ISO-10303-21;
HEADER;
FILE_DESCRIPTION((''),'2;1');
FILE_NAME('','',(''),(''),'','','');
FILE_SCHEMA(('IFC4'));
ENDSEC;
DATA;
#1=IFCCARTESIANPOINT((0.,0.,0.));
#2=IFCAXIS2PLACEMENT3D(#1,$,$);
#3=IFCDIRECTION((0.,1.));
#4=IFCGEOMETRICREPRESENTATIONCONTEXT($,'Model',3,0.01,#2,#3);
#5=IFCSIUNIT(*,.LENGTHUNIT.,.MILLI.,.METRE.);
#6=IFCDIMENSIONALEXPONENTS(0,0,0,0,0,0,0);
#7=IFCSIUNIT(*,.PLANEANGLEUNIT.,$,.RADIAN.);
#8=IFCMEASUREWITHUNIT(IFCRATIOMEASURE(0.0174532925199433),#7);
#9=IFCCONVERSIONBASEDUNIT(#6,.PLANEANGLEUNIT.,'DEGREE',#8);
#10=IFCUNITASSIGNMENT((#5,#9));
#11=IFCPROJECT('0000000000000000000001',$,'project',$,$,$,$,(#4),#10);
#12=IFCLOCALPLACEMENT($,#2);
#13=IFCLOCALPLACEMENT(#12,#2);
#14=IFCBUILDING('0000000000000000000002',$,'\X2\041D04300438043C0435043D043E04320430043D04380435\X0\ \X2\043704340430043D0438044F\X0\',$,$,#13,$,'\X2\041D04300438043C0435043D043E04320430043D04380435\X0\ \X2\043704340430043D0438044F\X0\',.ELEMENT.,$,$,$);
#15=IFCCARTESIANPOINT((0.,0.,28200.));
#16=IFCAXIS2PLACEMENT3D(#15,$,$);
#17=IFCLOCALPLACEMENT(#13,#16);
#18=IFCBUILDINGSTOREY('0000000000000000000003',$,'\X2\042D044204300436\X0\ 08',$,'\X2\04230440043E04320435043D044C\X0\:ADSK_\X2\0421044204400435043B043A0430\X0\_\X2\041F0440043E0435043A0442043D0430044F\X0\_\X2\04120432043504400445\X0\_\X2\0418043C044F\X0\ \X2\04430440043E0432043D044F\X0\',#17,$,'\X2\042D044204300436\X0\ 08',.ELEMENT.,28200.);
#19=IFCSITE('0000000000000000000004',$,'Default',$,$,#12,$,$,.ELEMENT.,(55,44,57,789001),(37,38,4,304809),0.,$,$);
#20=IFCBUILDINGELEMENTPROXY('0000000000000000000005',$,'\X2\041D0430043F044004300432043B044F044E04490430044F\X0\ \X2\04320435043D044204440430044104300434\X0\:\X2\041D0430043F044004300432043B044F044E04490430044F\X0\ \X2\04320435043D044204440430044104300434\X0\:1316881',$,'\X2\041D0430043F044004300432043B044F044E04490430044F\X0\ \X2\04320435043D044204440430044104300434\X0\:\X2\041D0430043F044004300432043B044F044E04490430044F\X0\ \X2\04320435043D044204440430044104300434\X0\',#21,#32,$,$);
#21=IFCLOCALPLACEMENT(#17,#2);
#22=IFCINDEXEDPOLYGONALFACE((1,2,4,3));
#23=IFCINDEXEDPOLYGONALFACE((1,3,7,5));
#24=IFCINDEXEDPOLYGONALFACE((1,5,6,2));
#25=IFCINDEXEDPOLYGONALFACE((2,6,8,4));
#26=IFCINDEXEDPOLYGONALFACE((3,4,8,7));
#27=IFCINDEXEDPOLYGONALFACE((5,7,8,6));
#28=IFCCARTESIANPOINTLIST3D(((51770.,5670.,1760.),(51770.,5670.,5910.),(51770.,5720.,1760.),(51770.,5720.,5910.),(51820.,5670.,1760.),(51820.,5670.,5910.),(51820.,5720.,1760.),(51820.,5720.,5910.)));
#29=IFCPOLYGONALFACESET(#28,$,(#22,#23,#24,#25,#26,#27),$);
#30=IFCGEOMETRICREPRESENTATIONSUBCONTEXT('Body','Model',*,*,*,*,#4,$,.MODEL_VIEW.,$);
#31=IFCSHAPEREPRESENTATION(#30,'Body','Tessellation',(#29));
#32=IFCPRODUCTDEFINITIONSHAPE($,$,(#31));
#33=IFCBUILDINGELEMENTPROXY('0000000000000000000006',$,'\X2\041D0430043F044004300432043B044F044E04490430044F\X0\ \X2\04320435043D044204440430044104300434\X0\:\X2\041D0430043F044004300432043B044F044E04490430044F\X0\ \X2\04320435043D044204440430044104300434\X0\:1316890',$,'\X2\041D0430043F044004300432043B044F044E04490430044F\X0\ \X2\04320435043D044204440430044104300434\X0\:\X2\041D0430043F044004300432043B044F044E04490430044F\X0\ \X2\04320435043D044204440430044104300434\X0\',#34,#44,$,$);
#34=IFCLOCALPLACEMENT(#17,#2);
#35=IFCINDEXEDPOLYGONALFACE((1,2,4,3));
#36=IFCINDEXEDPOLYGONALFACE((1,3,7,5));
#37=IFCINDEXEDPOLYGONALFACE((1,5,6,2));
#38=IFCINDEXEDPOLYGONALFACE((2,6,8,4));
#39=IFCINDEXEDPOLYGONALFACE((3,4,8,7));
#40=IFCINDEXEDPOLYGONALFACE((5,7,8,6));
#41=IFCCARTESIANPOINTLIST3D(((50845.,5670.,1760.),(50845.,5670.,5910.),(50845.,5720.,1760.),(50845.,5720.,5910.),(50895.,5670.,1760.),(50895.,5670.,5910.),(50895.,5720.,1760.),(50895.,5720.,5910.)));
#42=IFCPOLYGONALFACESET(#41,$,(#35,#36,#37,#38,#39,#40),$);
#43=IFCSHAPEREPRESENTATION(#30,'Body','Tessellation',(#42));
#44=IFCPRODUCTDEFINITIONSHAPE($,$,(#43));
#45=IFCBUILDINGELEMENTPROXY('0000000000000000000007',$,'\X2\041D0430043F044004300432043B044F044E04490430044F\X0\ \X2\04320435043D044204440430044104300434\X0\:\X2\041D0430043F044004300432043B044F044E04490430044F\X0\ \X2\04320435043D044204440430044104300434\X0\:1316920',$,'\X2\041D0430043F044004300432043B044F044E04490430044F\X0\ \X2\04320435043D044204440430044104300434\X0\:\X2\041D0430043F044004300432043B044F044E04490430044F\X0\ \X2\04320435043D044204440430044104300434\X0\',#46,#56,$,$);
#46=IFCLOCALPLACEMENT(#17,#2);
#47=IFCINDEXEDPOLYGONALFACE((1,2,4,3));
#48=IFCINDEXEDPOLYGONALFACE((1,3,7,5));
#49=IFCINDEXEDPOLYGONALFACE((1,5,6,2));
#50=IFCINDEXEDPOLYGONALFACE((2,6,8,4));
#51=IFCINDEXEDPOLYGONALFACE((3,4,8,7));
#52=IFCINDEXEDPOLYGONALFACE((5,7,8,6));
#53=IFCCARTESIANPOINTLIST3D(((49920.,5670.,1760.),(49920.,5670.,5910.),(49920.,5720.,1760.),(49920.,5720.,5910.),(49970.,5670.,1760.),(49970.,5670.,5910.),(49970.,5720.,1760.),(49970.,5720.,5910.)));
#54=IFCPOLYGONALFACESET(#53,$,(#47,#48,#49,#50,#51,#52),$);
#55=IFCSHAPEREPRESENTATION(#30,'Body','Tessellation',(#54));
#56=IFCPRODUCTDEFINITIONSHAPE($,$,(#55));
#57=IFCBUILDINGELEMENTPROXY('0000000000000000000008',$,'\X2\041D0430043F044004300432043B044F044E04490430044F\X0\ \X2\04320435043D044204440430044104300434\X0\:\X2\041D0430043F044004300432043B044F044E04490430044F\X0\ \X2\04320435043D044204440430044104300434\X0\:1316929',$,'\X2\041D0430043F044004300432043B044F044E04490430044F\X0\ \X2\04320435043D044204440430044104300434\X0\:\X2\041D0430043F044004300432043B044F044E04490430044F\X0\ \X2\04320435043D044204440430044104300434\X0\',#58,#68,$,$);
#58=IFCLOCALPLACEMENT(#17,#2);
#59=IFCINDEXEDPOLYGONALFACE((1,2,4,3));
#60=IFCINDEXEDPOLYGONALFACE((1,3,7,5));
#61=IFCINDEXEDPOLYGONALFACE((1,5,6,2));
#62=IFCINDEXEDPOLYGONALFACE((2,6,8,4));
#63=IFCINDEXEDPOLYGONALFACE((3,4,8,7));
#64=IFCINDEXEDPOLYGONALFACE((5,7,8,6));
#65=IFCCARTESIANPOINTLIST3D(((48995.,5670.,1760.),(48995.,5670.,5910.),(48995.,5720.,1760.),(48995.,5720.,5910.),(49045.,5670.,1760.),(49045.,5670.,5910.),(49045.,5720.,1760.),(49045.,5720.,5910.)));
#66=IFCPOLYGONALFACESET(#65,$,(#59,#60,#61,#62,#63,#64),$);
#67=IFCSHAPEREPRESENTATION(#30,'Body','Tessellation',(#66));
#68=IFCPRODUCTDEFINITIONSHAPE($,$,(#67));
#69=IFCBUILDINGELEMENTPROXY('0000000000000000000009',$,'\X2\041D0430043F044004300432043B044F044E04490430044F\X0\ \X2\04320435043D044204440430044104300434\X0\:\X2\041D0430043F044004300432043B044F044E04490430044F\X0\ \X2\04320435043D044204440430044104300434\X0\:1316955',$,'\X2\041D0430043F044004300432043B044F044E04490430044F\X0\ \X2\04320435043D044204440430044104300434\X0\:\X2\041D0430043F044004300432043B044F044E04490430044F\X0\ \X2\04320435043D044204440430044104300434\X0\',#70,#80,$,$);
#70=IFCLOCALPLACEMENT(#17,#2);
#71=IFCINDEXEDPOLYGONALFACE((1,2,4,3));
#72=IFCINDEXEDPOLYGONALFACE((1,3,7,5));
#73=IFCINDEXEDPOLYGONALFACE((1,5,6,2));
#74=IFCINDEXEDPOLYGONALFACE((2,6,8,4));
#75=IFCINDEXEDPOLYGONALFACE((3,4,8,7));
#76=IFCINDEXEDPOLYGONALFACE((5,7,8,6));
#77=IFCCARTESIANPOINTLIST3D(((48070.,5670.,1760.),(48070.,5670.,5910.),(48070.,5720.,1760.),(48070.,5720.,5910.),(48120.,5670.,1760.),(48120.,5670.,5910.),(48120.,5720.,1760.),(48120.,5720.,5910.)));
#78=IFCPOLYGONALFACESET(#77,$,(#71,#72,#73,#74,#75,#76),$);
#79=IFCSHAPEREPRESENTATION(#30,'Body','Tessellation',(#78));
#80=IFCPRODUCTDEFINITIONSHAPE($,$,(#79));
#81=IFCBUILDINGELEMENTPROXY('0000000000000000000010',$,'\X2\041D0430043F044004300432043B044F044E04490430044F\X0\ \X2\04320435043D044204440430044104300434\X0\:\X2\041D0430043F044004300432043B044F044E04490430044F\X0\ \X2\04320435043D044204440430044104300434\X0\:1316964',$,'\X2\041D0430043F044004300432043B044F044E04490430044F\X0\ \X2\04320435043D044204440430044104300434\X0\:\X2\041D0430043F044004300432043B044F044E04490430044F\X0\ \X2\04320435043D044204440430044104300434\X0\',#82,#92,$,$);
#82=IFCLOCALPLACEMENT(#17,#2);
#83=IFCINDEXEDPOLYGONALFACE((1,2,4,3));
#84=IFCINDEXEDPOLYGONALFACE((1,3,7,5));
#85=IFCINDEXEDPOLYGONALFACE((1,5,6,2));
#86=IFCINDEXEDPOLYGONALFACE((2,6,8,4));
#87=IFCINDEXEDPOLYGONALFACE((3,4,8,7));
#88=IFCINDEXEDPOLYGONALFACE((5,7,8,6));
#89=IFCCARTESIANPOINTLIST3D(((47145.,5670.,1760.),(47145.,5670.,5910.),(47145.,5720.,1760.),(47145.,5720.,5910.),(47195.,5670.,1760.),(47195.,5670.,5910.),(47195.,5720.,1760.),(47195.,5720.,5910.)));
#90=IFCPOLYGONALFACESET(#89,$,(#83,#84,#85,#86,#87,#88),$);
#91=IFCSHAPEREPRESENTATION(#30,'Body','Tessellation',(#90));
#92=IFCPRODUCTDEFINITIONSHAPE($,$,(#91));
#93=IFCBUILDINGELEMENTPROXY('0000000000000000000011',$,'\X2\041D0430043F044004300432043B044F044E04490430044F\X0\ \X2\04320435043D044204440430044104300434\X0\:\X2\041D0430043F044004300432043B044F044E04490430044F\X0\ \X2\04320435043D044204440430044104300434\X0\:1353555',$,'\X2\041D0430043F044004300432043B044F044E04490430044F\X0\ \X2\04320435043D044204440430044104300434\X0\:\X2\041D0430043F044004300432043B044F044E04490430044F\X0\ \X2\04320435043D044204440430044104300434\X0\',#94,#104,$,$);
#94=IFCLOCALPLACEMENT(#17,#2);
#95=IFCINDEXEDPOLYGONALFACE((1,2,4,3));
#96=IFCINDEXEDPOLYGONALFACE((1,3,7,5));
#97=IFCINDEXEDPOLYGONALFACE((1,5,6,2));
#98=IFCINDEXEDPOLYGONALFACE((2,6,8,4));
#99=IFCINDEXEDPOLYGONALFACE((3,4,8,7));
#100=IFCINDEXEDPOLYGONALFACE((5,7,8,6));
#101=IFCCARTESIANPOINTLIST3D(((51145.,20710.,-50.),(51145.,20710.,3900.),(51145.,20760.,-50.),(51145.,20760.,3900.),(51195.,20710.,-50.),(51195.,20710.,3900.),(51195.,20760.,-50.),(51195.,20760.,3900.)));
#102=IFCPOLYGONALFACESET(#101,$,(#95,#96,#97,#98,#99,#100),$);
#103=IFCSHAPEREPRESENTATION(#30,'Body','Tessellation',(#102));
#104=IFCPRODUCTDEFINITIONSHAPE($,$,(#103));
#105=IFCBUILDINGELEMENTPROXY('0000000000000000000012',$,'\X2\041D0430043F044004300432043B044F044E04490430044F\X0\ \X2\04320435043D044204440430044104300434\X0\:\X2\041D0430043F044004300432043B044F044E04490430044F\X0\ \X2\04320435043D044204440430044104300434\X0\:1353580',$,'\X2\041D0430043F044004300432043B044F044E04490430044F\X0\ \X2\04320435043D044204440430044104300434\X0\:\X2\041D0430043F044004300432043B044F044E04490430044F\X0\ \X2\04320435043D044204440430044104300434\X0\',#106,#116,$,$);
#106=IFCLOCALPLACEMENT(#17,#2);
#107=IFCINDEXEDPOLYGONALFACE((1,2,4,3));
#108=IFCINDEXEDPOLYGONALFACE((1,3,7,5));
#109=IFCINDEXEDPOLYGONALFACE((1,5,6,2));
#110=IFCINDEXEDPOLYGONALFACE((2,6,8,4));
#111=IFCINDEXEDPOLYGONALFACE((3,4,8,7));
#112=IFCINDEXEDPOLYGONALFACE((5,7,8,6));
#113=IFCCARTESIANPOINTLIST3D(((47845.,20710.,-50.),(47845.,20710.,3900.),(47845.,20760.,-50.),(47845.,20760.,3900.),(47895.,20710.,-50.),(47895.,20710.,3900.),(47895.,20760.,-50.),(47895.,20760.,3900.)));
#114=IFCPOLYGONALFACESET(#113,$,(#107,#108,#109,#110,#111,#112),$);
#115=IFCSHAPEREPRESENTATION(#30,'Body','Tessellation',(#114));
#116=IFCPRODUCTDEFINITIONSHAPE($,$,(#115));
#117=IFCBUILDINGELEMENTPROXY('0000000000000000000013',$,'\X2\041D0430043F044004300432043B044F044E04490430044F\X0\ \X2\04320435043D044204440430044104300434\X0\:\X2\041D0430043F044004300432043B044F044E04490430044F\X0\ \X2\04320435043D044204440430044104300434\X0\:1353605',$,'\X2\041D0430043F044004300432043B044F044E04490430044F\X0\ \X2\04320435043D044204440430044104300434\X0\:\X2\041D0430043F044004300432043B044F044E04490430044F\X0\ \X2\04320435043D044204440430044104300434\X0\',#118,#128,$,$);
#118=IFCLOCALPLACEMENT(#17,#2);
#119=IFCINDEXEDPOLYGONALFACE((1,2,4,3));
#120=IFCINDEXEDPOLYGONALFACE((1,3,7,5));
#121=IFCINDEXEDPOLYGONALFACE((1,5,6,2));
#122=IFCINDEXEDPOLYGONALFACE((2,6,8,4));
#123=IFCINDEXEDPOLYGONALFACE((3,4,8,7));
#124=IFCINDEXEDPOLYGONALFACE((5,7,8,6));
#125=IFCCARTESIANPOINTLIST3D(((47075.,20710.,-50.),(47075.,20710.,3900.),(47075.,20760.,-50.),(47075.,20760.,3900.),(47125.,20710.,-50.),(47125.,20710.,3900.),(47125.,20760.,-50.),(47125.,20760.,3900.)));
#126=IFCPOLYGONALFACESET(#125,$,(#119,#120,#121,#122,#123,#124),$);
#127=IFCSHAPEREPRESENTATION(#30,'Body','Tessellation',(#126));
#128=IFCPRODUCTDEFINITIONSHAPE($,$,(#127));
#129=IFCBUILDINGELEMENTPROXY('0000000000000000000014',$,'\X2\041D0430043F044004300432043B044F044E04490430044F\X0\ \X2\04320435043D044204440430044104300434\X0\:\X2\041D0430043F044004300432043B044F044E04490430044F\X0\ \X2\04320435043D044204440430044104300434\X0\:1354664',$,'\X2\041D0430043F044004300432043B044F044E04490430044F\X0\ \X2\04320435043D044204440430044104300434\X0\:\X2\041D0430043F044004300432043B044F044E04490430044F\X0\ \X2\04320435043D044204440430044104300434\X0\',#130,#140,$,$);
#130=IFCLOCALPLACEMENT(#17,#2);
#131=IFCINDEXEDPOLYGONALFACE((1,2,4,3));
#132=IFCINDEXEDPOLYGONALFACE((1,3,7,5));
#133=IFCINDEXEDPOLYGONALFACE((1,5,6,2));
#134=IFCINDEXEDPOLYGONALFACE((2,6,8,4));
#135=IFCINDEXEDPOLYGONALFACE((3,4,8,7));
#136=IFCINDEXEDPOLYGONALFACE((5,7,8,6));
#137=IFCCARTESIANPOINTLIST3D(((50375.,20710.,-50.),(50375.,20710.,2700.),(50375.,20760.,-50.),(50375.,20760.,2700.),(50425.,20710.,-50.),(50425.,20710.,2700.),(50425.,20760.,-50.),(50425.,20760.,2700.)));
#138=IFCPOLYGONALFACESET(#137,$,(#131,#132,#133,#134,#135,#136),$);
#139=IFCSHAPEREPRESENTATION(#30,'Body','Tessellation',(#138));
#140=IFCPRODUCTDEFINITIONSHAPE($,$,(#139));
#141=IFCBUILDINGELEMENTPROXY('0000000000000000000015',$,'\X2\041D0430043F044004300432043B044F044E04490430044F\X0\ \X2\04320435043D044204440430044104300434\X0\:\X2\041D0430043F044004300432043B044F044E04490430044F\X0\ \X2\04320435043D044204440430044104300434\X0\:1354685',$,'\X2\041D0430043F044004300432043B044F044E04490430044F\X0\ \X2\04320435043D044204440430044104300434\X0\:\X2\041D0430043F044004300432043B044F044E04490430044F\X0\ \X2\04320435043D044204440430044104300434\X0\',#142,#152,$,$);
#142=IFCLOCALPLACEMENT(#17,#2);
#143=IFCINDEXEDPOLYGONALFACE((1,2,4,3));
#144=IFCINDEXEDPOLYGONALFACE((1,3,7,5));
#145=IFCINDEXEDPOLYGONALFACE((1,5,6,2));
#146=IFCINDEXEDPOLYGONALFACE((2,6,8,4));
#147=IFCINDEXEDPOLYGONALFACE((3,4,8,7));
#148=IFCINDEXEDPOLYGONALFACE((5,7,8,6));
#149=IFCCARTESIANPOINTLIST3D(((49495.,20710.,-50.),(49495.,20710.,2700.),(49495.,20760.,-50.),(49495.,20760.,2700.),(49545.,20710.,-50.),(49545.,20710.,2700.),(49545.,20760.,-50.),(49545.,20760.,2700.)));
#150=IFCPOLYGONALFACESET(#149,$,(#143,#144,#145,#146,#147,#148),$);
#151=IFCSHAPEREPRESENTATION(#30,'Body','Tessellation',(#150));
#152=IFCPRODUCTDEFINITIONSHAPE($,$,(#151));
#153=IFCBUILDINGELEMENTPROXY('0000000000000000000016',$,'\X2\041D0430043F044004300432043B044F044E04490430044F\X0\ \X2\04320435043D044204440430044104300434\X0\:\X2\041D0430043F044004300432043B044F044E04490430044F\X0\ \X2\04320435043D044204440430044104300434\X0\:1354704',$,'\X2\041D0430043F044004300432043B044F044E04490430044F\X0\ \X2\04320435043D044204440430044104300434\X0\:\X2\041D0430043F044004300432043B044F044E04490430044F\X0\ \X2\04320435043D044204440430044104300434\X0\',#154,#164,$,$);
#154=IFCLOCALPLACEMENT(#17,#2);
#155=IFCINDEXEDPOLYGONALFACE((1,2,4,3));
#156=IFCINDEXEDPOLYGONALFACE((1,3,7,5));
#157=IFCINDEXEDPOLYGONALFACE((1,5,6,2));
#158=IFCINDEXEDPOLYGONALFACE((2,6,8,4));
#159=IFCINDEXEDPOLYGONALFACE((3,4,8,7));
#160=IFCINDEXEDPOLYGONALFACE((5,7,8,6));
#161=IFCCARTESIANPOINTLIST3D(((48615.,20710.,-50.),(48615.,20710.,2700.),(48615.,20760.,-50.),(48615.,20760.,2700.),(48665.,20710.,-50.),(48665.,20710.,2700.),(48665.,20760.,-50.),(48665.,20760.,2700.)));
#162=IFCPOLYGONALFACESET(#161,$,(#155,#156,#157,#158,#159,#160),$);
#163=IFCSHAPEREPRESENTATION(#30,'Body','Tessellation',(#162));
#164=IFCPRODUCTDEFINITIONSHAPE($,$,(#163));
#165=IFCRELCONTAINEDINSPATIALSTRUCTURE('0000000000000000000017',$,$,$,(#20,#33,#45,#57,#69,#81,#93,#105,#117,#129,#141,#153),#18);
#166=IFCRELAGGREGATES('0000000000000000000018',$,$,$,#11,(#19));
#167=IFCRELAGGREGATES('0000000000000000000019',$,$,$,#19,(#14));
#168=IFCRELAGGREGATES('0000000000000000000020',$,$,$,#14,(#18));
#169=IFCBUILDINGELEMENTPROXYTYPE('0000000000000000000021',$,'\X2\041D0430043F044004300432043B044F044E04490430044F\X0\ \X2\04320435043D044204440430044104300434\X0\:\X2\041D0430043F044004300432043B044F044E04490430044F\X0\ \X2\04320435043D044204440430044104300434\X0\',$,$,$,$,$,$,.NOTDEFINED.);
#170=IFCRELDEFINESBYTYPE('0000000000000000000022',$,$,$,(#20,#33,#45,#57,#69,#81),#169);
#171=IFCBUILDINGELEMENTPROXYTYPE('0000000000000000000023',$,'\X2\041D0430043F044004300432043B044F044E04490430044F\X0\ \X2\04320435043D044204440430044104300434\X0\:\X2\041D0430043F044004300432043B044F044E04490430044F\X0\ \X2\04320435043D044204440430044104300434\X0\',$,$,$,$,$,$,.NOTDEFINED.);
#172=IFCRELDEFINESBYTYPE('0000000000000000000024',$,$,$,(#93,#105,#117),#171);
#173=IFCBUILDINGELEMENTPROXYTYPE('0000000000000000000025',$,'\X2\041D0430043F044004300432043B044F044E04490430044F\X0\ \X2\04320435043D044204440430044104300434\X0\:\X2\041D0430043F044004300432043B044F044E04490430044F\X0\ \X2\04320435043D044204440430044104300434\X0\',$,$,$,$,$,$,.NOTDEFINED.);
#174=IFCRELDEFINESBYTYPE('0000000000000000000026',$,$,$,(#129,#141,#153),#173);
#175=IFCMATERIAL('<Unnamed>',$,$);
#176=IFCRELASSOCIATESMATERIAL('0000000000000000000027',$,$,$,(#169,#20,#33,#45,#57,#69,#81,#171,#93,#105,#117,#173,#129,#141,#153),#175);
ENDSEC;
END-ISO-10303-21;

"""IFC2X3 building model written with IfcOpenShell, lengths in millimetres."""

from ifc_helpers import new_model, entity, si_unit, converted_unit, direction, frame, origin, origin_2d_with_axis, place, context, subcontext, project, spatial, rectangle, extrude, source, transform, mapped, material, type_object, type_shapes, element, save


model = new_model("IFC2X3")

# Units and contexts
model_context = context("Model", 3, precision=0.01, world=origin(), true_north=direction((0.0, 1.0)))
body_context = subcontext(model_context, "Body", "Model", "MODEL_VIEW")
ifc_project = project(units=[si_unit("LENGTHUNIT", "METRE", prefix="MILLI"), converted_unit("PLANEANGLEUNIT", "DEGREE", entity("IfcRatioMeasure", 0.0174532925199433), si_unit("PLANEANGLEUNIT", "RADIAN"), dimensions=[0, 0, 0, 0, 0, 0, 0])], contexts=[model_context])

# Site, building, storey
site_placement = place(None, origin())
site = spatial("IfcSite", under=ifc_project, at=site_placement, Name="Default", CompositionType="ELEMENT", RefLatitude=(55, 44, 57, 789001), RefLongitude=(37, 38, 4, 304809), RefElevation=0.0)
building_placement = place(site_placement, origin())
building = spatial("IfcBuilding", under=site, at=building_placement, Name="Наименование здания", LongName="Наименование здания", CompositionType="ELEMENT")
storey_placement = place(building_placement, frame((0.0, 0.0, 28200.0)))
storey = spatial("IfcBuildingStorey", under=building, at=storey_placement, Name="Этаж 08", ObjectType="Уровень:ADSK_Стрелка_Проектная_Вверх_Имя уровня", LongName="Этаж 08", CompositionType="ELEMENT", Elevation=28200.0)

# Building element proxies
ifc_material_1 = material(Name="<Unnamed>")
building_element_proxy_type_1 = type_object("IfcBuildingElementProxyType", Name="Направляющая вентфасад:Направляющая вентфасад", PredefinedType="NOTDEFINED", material=ifc_material_1)
shared_shape_1 = source(origin(), body_context, "Body", "SweptSolid", [
    extrude(rectangle(XDim=50.0, YDim=50.0, at=origin_2d_with_axis()), frame((25.0, -25.0, 0.0), z_axis=(0.0, 0.0, 1.0), x_axis=(-1.0, 0.0, 0.0)), (0.0, 0.0, 1.0), 4150.0),
])
type_shapes(building_element_proxy_type_1, [shared_shape_1])
for number, where, name in (
    (1, (51770.0, 5720.0, 1760.0), "Направляющая вентфасад:Направляющая вентфасад:1316881"),
    (2, (50845.0, 5720.0, 1760.0), "Направляющая вентфасад:Направляющая вентфасад:1316890"),
    (3, (49920.0, 5720.0, 1760.0), "Направляющая вентфасад:Направляющая вентфасад:1316920"),
    (4, (48995.0, 5720.0, 1760.0), "Направляющая вентфасад:Направляющая вентфасад:1316929"),
    (5, (48070.0, 5720.0, 1760.0), "Направляющая вентфасад:Направляющая вентфасад:1316955"),
    (6, (47145.0, 5720.0, 1760.0), "Направляющая вентфасад:Направляющая вентфасад:1316964"),
):
    element("IfcBuildingElementProxy", number, at=place(storey_placement, frame(where)), inside=storey, type_object=building_element_proxy_type_1, material=ifc_material_1, Name=name, ObjectType="Направляющая вентфасад:Направляющая вентфасад", context=body_context, shape_type="MappedRepresentation", body=[
        mapped(shared_shape_1, transform((0.0, 0.0, 0.0), scale=1.0)),
    ])
building_element_proxy_type_2 = type_object("IfcBuildingElementProxyType", Name="Направляющая вентфасад:Направляющая вентфасад", PredefinedType="NOTDEFINED", material=ifc_material_1)
shared_shape_2 = source(origin(), body_context, "Body", "SweptSolid", [
    extrude(rectangle(XDim=50.0, YDim=50.0, at=origin_2d_with_axis()), frame((25.0, -25.0, 0.0), z_axis=(0.0, 0.0, 1.0), x_axis=(-1.0, 0.0, 0.0)), (0.0, 0.0, 1.0), 3950.0),
])
type_shapes(building_element_proxy_type_2, [shared_shape_2])
for number, where, z_axis, x_axis, name in (
    (7, (51195.0, 20710.0, -50.0), (0.0, 0.0, 1.0), (-1.0, 0.0, 0.0), "Направляющая вентфасад:Направляющая вентфасад:1353555"),
    (8, (47895.0, 20710.0, -50.0), (0.0, 0.0, 1.0), (-1.0, 0.0, 0.0), "Направляющая вентфасад:Направляющая вентфасад:1353580"),
    (9, (47125.0, 20710.0, -50.0), (0.0, 0.0, 1.0), (-1.0, 0.0, 0.0), "Направляющая вентфасад:Направляющая вентфасад:1353605"),
):
    element("IfcBuildingElementProxy", number, at=place(storey_placement, frame(where, z_axis=z_axis, x_axis=x_axis)), inside=storey, type_object=building_element_proxy_type_2, material=ifc_material_1, Name=name, ObjectType="Направляющая вентфасад:Направляющая вентфасад", context=body_context, shape_type="MappedRepresentation", body=[
        mapped(shared_shape_2, transform((0.0, 0.0, 0.0), scale=1.0)),
    ])
building_element_proxy_type_3 = type_object("IfcBuildingElementProxyType", Name="Направляющая вентфасад:Направляющая вентфасад", PredefinedType="NOTDEFINED", material=ifc_material_1)
shared_shape_3 = source(origin(), body_context, "Body", "SweptSolid", [
    extrude(rectangle(XDim=50.0, YDim=50.0, at=origin_2d_with_axis()), frame((25.0, -25.0, 0.0), z_axis=(0.0, 0.0, 1.0), x_axis=(-1.0, 0.0, 0.0)), (0.0, 0.0, 1.0), 2750.0),
])
type_shapes(building_element_proxy_type_3, [shared_shape_3])
for number, where, z_axis, x_axis, name in (
    (10, (50425.0, 20710.0, -50.0), (0.0, 0.0, 1.0), (-1.0, 0.0, 0.0), "Направляющая вентфасад:Направляющая вентфасад:1354664"),
    (11, (49545.0, 20710.0, -50.0), (0.0, 0.0, 1.0), (-1.0, 0.0, 0.0), "Направляющая вентфасад:Направляющая вентфасад:1354685"),
    (12, (48665.0, 20710.0, -50.0), (0.0, 0.0, 1.0), (-1.0, 0.0, 0.0), "Направляющая вентфасад:Направляющая вентфасад:1354704"),
):
    element("IfcBuildingElementProxy", number, at=place(storey_placement, frame(where, z_axis=z_axis, x_axis=x_axis)), inside=storey, type_object=building_element_proxy_type_3, material=ifc_material_1, Name=name, ObjectType="Направляющая вентфасад:Направляющая вентфасад", context=body_context, shape_type="MappedRepresentation", body=[
        mapped(shared_shape_3, transform((0.0, 0.0, 0.0), scale=1.0)),
    ])

save(model, "model.ifc")
